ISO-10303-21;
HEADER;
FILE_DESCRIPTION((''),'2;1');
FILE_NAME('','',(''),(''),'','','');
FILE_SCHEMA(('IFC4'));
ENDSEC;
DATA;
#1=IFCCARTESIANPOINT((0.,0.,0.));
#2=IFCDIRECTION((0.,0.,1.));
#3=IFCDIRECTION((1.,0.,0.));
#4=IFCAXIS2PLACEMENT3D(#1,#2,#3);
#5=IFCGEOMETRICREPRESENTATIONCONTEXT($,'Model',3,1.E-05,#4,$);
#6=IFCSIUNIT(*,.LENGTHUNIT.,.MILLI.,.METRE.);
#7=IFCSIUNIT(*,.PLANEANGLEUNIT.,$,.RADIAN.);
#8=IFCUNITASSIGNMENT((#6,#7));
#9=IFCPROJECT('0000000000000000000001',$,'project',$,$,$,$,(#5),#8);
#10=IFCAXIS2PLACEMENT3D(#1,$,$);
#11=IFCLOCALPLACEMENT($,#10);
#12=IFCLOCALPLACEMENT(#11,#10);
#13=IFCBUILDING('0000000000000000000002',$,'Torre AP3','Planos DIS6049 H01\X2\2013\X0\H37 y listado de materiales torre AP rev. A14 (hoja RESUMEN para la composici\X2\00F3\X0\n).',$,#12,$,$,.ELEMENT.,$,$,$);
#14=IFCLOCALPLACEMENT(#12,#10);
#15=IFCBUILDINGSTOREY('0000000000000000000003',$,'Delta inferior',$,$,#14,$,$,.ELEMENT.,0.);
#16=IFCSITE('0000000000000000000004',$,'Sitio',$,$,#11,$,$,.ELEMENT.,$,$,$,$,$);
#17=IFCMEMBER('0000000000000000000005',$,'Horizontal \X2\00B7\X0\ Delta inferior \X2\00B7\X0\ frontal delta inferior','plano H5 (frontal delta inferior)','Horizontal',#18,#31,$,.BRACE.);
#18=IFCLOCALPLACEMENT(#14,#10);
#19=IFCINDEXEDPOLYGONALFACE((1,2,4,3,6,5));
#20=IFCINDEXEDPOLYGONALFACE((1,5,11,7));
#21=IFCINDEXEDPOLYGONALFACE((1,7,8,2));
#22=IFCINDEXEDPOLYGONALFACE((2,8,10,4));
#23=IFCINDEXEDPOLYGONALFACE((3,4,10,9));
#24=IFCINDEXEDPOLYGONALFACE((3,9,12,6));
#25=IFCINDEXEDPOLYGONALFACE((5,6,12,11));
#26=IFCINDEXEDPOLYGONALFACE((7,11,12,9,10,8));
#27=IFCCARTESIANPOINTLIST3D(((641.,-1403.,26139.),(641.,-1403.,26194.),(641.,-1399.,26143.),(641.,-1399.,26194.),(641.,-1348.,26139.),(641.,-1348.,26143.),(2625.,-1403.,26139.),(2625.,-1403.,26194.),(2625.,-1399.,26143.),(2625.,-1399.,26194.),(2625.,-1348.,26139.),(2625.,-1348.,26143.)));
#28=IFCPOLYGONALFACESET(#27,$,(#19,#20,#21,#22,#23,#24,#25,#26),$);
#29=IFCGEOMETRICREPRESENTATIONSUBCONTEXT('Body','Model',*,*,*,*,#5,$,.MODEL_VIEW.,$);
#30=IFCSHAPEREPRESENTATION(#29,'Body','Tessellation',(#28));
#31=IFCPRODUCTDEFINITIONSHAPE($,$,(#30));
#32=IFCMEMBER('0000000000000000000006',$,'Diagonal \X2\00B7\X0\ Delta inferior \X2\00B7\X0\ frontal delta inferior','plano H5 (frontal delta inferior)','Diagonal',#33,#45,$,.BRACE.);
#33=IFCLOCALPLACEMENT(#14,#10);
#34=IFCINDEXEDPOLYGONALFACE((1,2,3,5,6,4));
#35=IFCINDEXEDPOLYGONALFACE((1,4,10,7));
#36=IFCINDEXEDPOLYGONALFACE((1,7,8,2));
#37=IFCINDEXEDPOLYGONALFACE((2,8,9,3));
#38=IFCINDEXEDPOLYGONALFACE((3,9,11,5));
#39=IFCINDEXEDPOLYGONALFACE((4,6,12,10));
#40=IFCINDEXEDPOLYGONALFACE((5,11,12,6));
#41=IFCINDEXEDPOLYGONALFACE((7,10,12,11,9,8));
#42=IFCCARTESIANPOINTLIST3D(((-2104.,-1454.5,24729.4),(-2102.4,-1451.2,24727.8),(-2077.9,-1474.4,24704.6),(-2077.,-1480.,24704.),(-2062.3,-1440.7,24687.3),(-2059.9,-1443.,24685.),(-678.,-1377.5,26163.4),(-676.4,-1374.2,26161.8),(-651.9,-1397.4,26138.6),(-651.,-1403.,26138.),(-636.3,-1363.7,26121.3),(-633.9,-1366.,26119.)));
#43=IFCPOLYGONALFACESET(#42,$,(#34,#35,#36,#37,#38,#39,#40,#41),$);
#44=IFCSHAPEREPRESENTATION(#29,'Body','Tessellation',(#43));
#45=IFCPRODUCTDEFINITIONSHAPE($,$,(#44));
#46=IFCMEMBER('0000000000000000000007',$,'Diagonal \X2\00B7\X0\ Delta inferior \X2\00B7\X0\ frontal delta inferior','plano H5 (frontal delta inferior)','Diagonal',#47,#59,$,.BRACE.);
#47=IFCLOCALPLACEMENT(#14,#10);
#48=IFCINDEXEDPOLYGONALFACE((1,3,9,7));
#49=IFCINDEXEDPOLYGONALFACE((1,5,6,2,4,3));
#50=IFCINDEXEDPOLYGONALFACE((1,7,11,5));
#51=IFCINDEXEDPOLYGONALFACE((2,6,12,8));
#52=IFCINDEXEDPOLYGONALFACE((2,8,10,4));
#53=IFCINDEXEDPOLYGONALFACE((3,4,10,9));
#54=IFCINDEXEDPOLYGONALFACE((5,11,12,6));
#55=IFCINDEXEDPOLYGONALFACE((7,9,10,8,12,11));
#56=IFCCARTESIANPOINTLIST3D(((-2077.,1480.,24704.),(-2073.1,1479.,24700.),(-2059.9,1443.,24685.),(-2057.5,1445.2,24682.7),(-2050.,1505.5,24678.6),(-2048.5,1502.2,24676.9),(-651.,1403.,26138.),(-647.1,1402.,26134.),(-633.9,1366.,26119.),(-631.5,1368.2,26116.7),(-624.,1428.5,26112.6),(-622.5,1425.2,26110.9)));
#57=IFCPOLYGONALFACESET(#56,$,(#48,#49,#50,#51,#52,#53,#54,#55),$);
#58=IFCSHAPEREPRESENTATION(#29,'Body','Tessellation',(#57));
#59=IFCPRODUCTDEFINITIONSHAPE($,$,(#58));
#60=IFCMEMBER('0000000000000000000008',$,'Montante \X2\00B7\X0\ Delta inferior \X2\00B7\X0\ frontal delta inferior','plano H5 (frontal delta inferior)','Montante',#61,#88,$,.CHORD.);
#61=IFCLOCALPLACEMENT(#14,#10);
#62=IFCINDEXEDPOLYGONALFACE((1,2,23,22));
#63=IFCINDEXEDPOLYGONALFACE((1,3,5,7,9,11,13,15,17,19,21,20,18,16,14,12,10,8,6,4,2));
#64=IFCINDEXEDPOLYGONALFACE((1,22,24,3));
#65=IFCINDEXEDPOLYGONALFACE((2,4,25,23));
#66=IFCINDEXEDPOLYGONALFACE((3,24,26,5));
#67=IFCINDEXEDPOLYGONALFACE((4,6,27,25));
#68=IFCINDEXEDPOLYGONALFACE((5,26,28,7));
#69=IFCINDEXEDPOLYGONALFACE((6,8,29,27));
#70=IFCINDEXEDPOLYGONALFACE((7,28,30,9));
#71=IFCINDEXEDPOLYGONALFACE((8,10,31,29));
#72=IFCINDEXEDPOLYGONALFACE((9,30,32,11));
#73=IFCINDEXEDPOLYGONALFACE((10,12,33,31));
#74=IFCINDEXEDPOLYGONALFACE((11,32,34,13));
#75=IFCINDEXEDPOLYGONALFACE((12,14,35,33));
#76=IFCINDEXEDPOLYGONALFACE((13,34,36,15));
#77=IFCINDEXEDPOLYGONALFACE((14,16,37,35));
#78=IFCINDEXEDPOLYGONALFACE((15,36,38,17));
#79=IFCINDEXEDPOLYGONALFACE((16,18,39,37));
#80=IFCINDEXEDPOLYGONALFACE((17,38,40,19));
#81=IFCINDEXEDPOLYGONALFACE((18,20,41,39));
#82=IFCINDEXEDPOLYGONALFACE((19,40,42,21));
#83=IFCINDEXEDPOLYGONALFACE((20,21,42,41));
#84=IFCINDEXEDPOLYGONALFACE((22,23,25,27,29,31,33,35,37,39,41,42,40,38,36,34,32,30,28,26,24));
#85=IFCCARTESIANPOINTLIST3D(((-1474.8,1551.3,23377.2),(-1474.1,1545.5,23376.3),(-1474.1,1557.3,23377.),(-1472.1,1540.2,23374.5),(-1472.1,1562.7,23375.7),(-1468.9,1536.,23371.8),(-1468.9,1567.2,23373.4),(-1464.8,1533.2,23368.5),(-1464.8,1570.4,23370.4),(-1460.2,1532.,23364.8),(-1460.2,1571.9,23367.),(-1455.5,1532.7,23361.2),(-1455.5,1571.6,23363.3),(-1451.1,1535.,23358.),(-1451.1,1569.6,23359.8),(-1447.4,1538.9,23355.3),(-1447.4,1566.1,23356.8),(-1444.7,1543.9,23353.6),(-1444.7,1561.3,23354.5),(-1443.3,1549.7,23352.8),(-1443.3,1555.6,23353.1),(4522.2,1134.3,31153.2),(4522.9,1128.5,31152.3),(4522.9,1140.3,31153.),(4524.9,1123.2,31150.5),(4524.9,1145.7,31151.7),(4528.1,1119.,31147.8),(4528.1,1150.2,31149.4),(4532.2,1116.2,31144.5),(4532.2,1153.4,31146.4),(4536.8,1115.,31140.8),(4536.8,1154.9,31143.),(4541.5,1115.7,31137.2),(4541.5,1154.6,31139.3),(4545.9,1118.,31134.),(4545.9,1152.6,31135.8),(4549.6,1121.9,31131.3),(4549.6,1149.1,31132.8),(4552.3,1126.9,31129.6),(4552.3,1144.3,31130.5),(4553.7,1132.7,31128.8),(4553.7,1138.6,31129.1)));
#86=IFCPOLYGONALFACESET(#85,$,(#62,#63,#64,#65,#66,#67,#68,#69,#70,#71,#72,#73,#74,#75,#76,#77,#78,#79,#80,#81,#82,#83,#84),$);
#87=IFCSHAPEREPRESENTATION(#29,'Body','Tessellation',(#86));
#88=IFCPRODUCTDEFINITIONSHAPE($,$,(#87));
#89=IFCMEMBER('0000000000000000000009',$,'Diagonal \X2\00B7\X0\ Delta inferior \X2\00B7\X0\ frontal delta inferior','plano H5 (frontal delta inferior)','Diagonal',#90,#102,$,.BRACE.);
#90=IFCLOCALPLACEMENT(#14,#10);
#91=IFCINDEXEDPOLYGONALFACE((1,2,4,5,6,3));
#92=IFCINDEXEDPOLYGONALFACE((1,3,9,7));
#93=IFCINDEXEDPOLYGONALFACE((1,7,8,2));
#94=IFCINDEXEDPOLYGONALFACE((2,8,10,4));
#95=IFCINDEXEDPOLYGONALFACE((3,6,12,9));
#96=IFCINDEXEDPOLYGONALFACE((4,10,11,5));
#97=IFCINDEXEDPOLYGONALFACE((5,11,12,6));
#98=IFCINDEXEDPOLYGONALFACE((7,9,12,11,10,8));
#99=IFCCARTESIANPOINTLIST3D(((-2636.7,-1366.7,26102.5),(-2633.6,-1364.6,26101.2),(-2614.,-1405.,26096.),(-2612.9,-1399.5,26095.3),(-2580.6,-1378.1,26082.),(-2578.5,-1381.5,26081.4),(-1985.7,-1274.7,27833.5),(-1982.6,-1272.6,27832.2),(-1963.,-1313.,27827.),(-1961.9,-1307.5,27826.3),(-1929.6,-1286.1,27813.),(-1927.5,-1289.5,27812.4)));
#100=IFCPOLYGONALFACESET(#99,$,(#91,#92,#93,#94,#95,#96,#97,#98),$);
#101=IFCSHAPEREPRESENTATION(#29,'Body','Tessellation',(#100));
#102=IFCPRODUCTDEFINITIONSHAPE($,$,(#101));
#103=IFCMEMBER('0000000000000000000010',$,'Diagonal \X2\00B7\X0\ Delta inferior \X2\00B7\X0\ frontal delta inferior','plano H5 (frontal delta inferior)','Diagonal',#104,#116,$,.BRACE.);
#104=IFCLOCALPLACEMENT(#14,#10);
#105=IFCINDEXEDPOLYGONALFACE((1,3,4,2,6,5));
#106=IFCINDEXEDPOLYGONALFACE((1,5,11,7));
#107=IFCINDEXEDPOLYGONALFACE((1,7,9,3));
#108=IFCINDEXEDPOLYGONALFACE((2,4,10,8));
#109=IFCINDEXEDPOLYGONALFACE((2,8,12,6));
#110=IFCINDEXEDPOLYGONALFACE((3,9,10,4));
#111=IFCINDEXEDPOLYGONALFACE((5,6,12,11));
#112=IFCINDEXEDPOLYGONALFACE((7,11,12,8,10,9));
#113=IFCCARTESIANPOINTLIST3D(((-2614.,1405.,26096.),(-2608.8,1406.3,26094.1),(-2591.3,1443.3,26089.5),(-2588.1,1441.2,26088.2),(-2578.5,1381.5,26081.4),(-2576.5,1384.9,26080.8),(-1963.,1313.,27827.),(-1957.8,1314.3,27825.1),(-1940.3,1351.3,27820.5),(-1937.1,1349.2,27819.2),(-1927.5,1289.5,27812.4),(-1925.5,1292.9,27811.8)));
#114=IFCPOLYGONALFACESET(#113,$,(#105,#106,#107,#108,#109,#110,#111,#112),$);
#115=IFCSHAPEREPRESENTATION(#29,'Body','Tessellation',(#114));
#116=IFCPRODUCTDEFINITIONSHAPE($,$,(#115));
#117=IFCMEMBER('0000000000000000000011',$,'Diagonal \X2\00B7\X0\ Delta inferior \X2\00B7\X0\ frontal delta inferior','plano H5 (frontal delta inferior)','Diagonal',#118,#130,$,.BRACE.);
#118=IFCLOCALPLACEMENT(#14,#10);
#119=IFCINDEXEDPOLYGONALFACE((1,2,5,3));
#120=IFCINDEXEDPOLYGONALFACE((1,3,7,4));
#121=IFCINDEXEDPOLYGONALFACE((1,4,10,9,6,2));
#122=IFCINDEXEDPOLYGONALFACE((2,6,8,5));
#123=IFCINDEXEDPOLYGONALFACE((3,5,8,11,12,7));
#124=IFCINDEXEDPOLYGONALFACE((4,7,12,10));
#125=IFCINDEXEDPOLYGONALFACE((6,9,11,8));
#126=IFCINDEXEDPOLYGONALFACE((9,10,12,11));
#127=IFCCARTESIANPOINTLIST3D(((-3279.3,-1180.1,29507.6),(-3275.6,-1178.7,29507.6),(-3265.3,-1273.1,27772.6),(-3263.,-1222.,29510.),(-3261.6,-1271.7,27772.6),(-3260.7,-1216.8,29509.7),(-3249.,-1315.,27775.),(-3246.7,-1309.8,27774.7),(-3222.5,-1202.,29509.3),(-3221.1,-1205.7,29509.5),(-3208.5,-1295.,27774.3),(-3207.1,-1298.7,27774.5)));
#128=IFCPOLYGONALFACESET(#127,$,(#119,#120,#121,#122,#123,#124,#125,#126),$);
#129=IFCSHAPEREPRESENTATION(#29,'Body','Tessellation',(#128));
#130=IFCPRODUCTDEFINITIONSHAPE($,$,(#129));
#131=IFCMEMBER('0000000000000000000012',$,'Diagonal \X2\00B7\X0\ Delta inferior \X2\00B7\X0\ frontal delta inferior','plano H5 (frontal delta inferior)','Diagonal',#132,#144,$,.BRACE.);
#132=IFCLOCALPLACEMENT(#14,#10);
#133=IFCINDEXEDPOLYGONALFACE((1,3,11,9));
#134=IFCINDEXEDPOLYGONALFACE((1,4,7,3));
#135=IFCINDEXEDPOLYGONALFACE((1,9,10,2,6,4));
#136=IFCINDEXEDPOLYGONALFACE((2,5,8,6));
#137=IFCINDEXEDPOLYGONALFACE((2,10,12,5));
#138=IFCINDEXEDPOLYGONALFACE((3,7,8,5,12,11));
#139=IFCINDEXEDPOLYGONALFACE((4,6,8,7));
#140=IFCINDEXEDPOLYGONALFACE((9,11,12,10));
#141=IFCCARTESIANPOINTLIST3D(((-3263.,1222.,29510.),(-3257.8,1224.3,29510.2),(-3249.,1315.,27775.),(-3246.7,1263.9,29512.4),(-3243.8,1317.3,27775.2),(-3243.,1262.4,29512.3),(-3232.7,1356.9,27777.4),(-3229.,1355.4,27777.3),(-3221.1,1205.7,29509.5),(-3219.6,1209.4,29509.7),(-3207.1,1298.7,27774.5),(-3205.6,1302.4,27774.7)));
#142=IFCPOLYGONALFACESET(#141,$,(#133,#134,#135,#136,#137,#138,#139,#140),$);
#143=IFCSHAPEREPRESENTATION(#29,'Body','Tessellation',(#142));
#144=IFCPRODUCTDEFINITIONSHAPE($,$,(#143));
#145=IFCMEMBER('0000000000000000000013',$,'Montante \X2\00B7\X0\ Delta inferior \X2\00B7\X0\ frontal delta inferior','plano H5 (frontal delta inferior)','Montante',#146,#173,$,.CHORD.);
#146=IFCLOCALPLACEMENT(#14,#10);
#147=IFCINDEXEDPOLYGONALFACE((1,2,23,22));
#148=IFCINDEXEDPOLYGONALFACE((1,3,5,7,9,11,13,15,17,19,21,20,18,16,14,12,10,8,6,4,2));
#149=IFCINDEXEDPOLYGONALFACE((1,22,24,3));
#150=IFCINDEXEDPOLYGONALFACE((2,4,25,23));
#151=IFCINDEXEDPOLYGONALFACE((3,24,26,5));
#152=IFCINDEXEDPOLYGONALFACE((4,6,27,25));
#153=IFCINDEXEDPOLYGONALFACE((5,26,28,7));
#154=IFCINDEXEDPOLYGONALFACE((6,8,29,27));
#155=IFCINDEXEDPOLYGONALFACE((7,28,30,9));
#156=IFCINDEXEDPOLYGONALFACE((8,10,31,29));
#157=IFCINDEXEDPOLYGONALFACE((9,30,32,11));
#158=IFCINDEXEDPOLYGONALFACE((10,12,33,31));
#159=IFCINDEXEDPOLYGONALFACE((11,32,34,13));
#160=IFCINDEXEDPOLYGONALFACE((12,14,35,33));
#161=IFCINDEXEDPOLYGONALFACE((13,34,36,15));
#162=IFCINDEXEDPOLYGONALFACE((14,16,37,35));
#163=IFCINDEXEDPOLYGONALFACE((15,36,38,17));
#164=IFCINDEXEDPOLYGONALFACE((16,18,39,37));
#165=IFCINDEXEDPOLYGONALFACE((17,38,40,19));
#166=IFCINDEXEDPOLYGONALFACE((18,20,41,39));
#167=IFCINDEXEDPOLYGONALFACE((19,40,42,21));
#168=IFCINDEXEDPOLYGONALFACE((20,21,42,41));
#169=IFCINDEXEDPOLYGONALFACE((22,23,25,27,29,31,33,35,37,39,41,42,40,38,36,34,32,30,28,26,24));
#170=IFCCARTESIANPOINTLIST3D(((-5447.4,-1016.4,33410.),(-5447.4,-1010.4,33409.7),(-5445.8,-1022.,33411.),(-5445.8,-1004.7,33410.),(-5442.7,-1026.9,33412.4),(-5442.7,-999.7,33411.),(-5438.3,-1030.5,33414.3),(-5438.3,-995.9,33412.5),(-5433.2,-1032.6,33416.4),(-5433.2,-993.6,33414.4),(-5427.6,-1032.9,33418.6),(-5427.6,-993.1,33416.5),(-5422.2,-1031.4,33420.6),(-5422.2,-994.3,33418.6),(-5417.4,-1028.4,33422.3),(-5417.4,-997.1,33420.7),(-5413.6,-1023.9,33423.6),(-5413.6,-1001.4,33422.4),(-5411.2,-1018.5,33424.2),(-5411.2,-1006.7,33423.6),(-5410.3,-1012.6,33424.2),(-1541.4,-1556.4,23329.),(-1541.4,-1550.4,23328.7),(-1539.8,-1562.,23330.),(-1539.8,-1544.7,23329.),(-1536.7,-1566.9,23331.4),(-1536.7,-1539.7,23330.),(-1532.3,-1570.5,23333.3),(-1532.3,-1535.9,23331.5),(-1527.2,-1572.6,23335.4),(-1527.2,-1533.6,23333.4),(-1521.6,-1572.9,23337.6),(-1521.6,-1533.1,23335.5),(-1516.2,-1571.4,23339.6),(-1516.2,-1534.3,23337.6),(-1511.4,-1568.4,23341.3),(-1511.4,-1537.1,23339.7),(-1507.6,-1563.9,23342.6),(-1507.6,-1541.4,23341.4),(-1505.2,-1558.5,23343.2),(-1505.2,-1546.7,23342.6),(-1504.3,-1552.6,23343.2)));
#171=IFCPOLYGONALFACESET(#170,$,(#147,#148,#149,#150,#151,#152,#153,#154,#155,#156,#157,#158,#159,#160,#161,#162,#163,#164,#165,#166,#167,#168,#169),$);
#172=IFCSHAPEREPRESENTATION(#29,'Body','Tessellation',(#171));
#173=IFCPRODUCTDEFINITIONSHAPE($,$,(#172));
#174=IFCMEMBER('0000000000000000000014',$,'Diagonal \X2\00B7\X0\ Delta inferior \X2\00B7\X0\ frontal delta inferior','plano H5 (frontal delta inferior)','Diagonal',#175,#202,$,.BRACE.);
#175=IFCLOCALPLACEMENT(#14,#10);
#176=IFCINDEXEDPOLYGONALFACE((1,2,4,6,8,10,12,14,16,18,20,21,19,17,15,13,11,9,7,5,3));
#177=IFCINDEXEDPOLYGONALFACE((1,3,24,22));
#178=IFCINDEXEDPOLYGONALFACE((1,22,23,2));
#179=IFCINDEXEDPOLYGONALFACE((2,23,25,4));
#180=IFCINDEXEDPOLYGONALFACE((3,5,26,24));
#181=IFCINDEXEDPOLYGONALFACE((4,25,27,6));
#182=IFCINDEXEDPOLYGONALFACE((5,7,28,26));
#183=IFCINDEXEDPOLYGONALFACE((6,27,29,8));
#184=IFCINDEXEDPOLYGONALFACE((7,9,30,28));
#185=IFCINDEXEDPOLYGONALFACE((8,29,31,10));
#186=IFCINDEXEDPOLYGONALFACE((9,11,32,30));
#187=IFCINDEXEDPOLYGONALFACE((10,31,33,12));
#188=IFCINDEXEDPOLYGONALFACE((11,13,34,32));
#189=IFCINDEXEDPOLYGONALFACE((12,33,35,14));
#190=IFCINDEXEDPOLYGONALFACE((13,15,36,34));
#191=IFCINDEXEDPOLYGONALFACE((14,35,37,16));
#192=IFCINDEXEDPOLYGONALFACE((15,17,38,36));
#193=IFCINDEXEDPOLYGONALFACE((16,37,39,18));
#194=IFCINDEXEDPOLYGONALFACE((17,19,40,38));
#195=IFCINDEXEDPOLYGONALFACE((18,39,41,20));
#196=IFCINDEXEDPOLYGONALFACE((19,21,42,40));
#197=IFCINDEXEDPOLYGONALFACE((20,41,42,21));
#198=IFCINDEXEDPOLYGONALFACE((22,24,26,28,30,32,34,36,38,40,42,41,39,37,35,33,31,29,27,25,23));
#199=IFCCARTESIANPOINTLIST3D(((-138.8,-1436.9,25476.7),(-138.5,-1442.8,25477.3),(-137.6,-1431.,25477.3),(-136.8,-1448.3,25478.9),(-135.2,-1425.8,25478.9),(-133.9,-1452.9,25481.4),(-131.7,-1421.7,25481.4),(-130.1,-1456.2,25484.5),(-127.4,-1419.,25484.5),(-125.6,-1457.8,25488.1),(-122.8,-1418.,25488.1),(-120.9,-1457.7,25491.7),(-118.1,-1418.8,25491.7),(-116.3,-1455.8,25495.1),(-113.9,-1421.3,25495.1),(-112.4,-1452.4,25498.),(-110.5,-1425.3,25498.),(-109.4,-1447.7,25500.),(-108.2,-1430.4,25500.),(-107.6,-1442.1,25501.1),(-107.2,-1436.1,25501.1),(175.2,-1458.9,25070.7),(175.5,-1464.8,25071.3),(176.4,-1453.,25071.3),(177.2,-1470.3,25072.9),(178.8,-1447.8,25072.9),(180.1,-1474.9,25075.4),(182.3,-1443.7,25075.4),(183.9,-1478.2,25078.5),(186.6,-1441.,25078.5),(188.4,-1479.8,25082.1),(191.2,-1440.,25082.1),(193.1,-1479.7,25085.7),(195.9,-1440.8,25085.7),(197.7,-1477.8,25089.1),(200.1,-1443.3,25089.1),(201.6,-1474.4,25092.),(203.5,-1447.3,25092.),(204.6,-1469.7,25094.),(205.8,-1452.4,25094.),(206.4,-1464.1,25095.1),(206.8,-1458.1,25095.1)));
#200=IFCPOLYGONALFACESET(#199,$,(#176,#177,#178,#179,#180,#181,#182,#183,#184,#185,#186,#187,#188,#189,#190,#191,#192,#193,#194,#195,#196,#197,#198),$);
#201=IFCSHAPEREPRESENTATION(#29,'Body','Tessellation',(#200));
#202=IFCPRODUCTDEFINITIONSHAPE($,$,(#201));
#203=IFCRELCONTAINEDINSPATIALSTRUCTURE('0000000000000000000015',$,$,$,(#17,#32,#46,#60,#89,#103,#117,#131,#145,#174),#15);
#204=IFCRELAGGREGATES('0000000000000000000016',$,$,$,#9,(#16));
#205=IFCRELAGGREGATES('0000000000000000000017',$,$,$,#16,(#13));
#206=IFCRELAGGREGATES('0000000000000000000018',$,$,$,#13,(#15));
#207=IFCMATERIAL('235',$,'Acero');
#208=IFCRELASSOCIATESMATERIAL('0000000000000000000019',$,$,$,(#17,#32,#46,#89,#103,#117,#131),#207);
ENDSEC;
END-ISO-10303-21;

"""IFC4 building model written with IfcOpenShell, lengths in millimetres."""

from ifc_helpers import new_model, si_unit, frame, frame_2d, origin, origin_with_axes, place, context, subcontext, project, spatial, circle, l_section, extrude, material, element, save


model = new_model("IFC4")

# Units and contexts
model_context = context("Model", 3, precision=1e-05, world=origin_with_axes())
body_context = subcontext(model_context, "Body", "Model", "MODEL_VIEW")
ifc_project = project(units=[si_unit("LENGTHUNIT", "METRE", prefix="MILLI"), si_unit("PLANEANGLEUNIT", "RADIAN")], contexts=[model_context])

# Site, building, storey
site_placement = place(None, origin())
site = spatial("IfcSite", under=ifc_project, at=site_placement, Name="Sitio", CompositionType="ELEMENT")
building_placement = place(site_placement, origin())
building = spatial("IfcBuilding", under=site, at=building_placement, Name="Torre AP3", Description="Planos DIS6049 H01–H37 y listado de materiales torre AP rev. A14 (hoja RESUMEN para la composición).", CompositionType="ELEMENT")
storey_placement = place(building_placement, origin())
storey = spatial("IfcBuildingStorey", under=building, at=storey_placement, Name="Delta inferior", CompositionType="ELEMENT", Elevation=0.0)

# Members
ifc_material_1 = material(Name="235", Category="Acero")
member_1_placement = place(storey_placement, frame((641.0, -1403.0, 26139.0), z_axis=(1.0, 0.0, 0.0), x_axis=(0.0, 1.0, 0.0)))
element("IfcMember", 1, at=member_1_placement, inside=storey, material=ifc_material_1, Name="Horizontal · Delta inferior · frontal delta inferior", Description="plano H5 (frontal delta inferior)", ObjectType="Horizontal", PredefinedType="BRACE", context=body_context, shape_type="SweptSolid", body=[
    extrude(l_section(Depth=55.0, Width=55.0, Thickness=4.0, at=frame_2d((27.5, 27.5))), None, (0.0, 0.0, 1.0), 1984.0),
])
for number, where, z_axis, x_axis, name in (
    (2, (-2077.0, -1480.0, 24704.0), (0.704616, 0.038047, 0.708569), (0.380197, 0.822889, -0.422261), "Diagonal · Delta inferior · frontal delta inferior"),
    (3, (-2077.0, 1480.0, 24704.0), (0.704616, -0.038047, 0.708569), (0.380197, -0.822889, -0.422261), "Diagonal · Delta inferior · frontal delta inferior"),
):
    element("IfcMember", number, at=place(storey_placement, frame(where, z_axis=z_axis, x_axis=x_axis)), inside=storey, material=ifc_material_1, Name=name, Description="plano H5 (frontal delta inferior)", ObjectType="Diagonal", PredefinedType="BRACE", context=body_context, shape_type="SweptSolid", body=[
        extrude(l_section(Depth=45.0, Width=45.0, Thickness=4.0, at=frame_2d((22.5, 22.5))), None, (0.0, 0.0, 1.0), 2023.8),
    ])
for number, where, z_axis, x_axis, name in (
    (4, (-1459.0, 1552.0, 23365.0), (0.61015, -0.042427, 0.791149), (-0.792286, -0.032673, 0.609274), "Montante · Delta inferior · frontal delta inferior"),
):
    element("IfcMember", number, at=place(storey_placement, frame(where, z_axis=z_axis, x_axis=x_axis)), inside=storey, Name=name, Description="plano H5 (frontal delta inferior)", ObjectType="Montante", PredefinedType="CHORD", context=body_context, shape_type="SweptSolid", body=[
        extrude(circle(Radius=20.0), None, (0.0, 0.0, 1.0), 9828.7),
    ])
for number, where, z_axis, x_axis, name in (
    (5, (-2614.0, -1405.0, 26096.0), (0.351577, 0.049685, 0.934839), (0.788131, 0.523198, -0.32421), "Diagonal · Delta inferior · frontal delta inferior"),
    (6, (-2614.0, 1405.0, 26096.0), (0.351577, -0.049685, 0.934839), (0.788131, -0.523198, -0.32421), "Diagonal · Delta inferior · frontal delta inferior"),
):
    element("IfcMember", number, at=place(storey_placement, frame(where, z_axis=z_axis, x_axis=x_axis)), inside=storey, material=ifc_material_1, Name=name, Description="plano H5 (frontal delta inferior)", ObjectType="Diagonal", PredefinedType="BRACE", context=body_context, shape_type="SweptSolid", body=[
        extrude(l_section(Depth=45.0, Width=45.0, Thickness=4.0, at=frame_2d((22.5, 22.5))), None, (0.0, 0.0, 1.0), 1851.7),
    ])
for number, where, z_axis, x_axis, name in (
    (7, (-3249.0, -1315.0, 27775.0), (-0.008057, 0.053524, 0.998534), (0.931947, 0.3624, -0.011905), "Diagonal · Delta inferior · frontal delta inferior"),
    (8, (-3249.0, 1315.0, 27775.0), (-0.008057, -0.053524, 0.998534), (0.931947, -0.3624, -0.011905), "Diagonal · Delta inferior · frontal delta inferior"),
):
    element("IfcMember", number, at=place(storey_placement, frame(where, z_axis=z_axis, x_axis=x_axis)), inside=storey, material=ifc_material_1, Name=name, Description="plano H5 (frontal delta inferior)", ObjectType="Diagonal", PredefinedType="BRACE", context=body_context, shape_type="SweptSolid", body=[
        extrude(l_section(Depth=45.0, Width=45.0, Thickness=4.0, at=frame_2d((22.5, 22.5))), None, (0.0, 0.0, 1.0), 1737.5),
    ])
for number, where, z_axis, x_axis, name in (
    (9, (-1523.0, -1553.0, 23336.0), (-0.36084, 0.049886, 0.931293), (0.932628, 0.019301, 0.360324), "Montante · Delta inferior · frontal delta inferior"),
):
    element("IfcMember", number, at=place(storey_placement, frame(where, z_axis=z_axis, x_axis=x_axis)), inside=storey, Name=name, Description="plano H5 (frontal delta inferior)", ObjectType="Montante", PredefinedType="CHORD", context=body_context, shape_type="SweptSolid", body=[
        extrude(circle(Radius=20.0), None, (0.0, 0.0, 1.0), 10824.7),
    ])
for number, where, z_axis, x_axis, name in (
    (10, (191.0, -1460.0, 25083.0), (-0.611219, 0.042824, 0.790302), (0.011492, 0.99891, -0.04524), "Diagonal · Delta inferior · frontal delta inferior"),
):
    element("IfcMember", number, at=place(storey_placement, frame(where, z_axis=z_axis, x_axis=x_axis)), inside=storey, Name=name, Description="plano H5 (frontal delta inferior)", ObjectType="Diagonal", PredefinedType="BRACE", context=body_context, shape_type="SweptSolid", body=[
        extrude(circle(Radius=20.0), None, (0.0, 0.0, 1.0), 513.7),
    ])

save(model, "model.ifc")
